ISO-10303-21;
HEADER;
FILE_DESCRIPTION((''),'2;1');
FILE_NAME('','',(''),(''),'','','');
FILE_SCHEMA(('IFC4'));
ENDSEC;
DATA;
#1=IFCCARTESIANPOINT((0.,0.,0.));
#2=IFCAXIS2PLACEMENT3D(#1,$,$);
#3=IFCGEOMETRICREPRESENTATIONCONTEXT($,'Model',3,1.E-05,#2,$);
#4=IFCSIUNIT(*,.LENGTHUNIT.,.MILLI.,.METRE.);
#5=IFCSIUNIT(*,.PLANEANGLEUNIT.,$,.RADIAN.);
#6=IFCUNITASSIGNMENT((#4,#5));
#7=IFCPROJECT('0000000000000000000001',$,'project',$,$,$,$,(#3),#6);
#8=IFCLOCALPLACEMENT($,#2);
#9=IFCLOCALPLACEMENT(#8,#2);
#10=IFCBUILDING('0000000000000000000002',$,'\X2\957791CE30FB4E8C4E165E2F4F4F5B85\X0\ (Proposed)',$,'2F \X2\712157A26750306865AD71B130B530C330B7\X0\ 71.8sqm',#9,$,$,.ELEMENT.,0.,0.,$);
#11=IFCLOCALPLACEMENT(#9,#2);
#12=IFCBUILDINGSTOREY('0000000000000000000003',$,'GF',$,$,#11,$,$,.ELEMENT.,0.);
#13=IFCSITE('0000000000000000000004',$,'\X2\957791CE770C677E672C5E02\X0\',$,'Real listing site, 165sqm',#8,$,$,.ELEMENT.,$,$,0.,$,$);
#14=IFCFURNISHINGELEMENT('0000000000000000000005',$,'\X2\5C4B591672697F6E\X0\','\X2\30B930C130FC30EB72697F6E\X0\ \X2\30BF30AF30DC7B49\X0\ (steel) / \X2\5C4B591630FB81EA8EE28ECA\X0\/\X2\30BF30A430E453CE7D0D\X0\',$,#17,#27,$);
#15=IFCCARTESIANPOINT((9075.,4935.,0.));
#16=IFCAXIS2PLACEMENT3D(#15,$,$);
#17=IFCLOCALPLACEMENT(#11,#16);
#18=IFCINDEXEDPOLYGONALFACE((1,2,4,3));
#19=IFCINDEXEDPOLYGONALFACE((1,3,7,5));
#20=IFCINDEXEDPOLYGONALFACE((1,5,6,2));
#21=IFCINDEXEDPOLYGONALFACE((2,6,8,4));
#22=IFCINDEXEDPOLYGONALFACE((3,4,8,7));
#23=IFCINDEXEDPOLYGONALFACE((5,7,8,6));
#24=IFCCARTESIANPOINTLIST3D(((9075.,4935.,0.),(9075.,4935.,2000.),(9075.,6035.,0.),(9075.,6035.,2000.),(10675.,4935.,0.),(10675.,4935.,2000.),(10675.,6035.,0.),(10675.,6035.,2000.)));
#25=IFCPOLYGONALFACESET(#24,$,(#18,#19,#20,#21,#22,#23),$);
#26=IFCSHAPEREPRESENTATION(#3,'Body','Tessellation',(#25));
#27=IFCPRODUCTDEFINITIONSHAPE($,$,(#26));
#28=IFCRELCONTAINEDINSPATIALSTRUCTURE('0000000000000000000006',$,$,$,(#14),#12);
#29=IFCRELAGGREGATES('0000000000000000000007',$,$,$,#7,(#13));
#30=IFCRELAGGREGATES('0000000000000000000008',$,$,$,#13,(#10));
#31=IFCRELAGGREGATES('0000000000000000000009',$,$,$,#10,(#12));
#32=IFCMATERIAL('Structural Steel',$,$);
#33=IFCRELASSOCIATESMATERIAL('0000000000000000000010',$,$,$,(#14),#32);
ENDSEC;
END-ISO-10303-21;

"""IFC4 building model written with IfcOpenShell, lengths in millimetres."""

from ifc_helpers import new_model, si_unit, frame, frame_2d, origin, place, context, project, spatial, rectangle, extrude, material, element, save


model = new_model("IFC4")

# Units and contexts
model_context = context("Model", 3, precision=1e-05, world=origin())
ifc_project = project(units=[si_unit("LENGTHUNIT", "METRE", prefix="MILLI"), si_unit("PLANEANGLEUNIT", "RADIAN")], contexts=[model_context])

# Site, building, storey
site_placement = place(None, origin())
site = spatial("IfcSite", under=ifc_project, at=site_placement, Name="長野県松本市", ObjectType="Real listing site, 165sqm", CompositionType="ELEMENT", RefElevation=0.0)
building_placement = place(site_placement, origin())
building = spatial("IfcBuilding", under=site, at=building_placement, Name="長野・二世帯住宅 (Proposed)", ObjectType="2F 無垢材と断熱サッシ 71.8sqm", CompositionType="ELEMENT", ElevationOfRefHeight=0.0, ElevationOfTerrain=0.0)
storey_placement = place(building_placement, origin())
storey = spatial("IfcBuildingStorey", under=building, at=storey_placement, Name="GF", CompositionType="ELEMENT", Elevation=0.0)

# Shared definitions
ifc_material_1 = material(Name="Structural Steel")

# Furnishing element
furnishing_1_placement = place(storey_placement, frame((9075.0, 4935.0, 0.0)))
element("IfcFurnishingElement", 1, at=furnishing_1_placement, inside=storey, material=ifc_material_1, Name="屋外物置", Description="スチール物置 タクボ等 (steel) / 屋外・自転車/タイヤ収納", context=model_context, shape_type="SweptSolid", body=[
    extrude(rectangle(XDim=1600.0, YDim=1100.0, at=frame_2d((800.0, 550.0))), frame((9075.0, 4935.0, 0.0)), (0.0, 0.0, 1.0), 2000.0),
])

save(model, "model.ifc")
